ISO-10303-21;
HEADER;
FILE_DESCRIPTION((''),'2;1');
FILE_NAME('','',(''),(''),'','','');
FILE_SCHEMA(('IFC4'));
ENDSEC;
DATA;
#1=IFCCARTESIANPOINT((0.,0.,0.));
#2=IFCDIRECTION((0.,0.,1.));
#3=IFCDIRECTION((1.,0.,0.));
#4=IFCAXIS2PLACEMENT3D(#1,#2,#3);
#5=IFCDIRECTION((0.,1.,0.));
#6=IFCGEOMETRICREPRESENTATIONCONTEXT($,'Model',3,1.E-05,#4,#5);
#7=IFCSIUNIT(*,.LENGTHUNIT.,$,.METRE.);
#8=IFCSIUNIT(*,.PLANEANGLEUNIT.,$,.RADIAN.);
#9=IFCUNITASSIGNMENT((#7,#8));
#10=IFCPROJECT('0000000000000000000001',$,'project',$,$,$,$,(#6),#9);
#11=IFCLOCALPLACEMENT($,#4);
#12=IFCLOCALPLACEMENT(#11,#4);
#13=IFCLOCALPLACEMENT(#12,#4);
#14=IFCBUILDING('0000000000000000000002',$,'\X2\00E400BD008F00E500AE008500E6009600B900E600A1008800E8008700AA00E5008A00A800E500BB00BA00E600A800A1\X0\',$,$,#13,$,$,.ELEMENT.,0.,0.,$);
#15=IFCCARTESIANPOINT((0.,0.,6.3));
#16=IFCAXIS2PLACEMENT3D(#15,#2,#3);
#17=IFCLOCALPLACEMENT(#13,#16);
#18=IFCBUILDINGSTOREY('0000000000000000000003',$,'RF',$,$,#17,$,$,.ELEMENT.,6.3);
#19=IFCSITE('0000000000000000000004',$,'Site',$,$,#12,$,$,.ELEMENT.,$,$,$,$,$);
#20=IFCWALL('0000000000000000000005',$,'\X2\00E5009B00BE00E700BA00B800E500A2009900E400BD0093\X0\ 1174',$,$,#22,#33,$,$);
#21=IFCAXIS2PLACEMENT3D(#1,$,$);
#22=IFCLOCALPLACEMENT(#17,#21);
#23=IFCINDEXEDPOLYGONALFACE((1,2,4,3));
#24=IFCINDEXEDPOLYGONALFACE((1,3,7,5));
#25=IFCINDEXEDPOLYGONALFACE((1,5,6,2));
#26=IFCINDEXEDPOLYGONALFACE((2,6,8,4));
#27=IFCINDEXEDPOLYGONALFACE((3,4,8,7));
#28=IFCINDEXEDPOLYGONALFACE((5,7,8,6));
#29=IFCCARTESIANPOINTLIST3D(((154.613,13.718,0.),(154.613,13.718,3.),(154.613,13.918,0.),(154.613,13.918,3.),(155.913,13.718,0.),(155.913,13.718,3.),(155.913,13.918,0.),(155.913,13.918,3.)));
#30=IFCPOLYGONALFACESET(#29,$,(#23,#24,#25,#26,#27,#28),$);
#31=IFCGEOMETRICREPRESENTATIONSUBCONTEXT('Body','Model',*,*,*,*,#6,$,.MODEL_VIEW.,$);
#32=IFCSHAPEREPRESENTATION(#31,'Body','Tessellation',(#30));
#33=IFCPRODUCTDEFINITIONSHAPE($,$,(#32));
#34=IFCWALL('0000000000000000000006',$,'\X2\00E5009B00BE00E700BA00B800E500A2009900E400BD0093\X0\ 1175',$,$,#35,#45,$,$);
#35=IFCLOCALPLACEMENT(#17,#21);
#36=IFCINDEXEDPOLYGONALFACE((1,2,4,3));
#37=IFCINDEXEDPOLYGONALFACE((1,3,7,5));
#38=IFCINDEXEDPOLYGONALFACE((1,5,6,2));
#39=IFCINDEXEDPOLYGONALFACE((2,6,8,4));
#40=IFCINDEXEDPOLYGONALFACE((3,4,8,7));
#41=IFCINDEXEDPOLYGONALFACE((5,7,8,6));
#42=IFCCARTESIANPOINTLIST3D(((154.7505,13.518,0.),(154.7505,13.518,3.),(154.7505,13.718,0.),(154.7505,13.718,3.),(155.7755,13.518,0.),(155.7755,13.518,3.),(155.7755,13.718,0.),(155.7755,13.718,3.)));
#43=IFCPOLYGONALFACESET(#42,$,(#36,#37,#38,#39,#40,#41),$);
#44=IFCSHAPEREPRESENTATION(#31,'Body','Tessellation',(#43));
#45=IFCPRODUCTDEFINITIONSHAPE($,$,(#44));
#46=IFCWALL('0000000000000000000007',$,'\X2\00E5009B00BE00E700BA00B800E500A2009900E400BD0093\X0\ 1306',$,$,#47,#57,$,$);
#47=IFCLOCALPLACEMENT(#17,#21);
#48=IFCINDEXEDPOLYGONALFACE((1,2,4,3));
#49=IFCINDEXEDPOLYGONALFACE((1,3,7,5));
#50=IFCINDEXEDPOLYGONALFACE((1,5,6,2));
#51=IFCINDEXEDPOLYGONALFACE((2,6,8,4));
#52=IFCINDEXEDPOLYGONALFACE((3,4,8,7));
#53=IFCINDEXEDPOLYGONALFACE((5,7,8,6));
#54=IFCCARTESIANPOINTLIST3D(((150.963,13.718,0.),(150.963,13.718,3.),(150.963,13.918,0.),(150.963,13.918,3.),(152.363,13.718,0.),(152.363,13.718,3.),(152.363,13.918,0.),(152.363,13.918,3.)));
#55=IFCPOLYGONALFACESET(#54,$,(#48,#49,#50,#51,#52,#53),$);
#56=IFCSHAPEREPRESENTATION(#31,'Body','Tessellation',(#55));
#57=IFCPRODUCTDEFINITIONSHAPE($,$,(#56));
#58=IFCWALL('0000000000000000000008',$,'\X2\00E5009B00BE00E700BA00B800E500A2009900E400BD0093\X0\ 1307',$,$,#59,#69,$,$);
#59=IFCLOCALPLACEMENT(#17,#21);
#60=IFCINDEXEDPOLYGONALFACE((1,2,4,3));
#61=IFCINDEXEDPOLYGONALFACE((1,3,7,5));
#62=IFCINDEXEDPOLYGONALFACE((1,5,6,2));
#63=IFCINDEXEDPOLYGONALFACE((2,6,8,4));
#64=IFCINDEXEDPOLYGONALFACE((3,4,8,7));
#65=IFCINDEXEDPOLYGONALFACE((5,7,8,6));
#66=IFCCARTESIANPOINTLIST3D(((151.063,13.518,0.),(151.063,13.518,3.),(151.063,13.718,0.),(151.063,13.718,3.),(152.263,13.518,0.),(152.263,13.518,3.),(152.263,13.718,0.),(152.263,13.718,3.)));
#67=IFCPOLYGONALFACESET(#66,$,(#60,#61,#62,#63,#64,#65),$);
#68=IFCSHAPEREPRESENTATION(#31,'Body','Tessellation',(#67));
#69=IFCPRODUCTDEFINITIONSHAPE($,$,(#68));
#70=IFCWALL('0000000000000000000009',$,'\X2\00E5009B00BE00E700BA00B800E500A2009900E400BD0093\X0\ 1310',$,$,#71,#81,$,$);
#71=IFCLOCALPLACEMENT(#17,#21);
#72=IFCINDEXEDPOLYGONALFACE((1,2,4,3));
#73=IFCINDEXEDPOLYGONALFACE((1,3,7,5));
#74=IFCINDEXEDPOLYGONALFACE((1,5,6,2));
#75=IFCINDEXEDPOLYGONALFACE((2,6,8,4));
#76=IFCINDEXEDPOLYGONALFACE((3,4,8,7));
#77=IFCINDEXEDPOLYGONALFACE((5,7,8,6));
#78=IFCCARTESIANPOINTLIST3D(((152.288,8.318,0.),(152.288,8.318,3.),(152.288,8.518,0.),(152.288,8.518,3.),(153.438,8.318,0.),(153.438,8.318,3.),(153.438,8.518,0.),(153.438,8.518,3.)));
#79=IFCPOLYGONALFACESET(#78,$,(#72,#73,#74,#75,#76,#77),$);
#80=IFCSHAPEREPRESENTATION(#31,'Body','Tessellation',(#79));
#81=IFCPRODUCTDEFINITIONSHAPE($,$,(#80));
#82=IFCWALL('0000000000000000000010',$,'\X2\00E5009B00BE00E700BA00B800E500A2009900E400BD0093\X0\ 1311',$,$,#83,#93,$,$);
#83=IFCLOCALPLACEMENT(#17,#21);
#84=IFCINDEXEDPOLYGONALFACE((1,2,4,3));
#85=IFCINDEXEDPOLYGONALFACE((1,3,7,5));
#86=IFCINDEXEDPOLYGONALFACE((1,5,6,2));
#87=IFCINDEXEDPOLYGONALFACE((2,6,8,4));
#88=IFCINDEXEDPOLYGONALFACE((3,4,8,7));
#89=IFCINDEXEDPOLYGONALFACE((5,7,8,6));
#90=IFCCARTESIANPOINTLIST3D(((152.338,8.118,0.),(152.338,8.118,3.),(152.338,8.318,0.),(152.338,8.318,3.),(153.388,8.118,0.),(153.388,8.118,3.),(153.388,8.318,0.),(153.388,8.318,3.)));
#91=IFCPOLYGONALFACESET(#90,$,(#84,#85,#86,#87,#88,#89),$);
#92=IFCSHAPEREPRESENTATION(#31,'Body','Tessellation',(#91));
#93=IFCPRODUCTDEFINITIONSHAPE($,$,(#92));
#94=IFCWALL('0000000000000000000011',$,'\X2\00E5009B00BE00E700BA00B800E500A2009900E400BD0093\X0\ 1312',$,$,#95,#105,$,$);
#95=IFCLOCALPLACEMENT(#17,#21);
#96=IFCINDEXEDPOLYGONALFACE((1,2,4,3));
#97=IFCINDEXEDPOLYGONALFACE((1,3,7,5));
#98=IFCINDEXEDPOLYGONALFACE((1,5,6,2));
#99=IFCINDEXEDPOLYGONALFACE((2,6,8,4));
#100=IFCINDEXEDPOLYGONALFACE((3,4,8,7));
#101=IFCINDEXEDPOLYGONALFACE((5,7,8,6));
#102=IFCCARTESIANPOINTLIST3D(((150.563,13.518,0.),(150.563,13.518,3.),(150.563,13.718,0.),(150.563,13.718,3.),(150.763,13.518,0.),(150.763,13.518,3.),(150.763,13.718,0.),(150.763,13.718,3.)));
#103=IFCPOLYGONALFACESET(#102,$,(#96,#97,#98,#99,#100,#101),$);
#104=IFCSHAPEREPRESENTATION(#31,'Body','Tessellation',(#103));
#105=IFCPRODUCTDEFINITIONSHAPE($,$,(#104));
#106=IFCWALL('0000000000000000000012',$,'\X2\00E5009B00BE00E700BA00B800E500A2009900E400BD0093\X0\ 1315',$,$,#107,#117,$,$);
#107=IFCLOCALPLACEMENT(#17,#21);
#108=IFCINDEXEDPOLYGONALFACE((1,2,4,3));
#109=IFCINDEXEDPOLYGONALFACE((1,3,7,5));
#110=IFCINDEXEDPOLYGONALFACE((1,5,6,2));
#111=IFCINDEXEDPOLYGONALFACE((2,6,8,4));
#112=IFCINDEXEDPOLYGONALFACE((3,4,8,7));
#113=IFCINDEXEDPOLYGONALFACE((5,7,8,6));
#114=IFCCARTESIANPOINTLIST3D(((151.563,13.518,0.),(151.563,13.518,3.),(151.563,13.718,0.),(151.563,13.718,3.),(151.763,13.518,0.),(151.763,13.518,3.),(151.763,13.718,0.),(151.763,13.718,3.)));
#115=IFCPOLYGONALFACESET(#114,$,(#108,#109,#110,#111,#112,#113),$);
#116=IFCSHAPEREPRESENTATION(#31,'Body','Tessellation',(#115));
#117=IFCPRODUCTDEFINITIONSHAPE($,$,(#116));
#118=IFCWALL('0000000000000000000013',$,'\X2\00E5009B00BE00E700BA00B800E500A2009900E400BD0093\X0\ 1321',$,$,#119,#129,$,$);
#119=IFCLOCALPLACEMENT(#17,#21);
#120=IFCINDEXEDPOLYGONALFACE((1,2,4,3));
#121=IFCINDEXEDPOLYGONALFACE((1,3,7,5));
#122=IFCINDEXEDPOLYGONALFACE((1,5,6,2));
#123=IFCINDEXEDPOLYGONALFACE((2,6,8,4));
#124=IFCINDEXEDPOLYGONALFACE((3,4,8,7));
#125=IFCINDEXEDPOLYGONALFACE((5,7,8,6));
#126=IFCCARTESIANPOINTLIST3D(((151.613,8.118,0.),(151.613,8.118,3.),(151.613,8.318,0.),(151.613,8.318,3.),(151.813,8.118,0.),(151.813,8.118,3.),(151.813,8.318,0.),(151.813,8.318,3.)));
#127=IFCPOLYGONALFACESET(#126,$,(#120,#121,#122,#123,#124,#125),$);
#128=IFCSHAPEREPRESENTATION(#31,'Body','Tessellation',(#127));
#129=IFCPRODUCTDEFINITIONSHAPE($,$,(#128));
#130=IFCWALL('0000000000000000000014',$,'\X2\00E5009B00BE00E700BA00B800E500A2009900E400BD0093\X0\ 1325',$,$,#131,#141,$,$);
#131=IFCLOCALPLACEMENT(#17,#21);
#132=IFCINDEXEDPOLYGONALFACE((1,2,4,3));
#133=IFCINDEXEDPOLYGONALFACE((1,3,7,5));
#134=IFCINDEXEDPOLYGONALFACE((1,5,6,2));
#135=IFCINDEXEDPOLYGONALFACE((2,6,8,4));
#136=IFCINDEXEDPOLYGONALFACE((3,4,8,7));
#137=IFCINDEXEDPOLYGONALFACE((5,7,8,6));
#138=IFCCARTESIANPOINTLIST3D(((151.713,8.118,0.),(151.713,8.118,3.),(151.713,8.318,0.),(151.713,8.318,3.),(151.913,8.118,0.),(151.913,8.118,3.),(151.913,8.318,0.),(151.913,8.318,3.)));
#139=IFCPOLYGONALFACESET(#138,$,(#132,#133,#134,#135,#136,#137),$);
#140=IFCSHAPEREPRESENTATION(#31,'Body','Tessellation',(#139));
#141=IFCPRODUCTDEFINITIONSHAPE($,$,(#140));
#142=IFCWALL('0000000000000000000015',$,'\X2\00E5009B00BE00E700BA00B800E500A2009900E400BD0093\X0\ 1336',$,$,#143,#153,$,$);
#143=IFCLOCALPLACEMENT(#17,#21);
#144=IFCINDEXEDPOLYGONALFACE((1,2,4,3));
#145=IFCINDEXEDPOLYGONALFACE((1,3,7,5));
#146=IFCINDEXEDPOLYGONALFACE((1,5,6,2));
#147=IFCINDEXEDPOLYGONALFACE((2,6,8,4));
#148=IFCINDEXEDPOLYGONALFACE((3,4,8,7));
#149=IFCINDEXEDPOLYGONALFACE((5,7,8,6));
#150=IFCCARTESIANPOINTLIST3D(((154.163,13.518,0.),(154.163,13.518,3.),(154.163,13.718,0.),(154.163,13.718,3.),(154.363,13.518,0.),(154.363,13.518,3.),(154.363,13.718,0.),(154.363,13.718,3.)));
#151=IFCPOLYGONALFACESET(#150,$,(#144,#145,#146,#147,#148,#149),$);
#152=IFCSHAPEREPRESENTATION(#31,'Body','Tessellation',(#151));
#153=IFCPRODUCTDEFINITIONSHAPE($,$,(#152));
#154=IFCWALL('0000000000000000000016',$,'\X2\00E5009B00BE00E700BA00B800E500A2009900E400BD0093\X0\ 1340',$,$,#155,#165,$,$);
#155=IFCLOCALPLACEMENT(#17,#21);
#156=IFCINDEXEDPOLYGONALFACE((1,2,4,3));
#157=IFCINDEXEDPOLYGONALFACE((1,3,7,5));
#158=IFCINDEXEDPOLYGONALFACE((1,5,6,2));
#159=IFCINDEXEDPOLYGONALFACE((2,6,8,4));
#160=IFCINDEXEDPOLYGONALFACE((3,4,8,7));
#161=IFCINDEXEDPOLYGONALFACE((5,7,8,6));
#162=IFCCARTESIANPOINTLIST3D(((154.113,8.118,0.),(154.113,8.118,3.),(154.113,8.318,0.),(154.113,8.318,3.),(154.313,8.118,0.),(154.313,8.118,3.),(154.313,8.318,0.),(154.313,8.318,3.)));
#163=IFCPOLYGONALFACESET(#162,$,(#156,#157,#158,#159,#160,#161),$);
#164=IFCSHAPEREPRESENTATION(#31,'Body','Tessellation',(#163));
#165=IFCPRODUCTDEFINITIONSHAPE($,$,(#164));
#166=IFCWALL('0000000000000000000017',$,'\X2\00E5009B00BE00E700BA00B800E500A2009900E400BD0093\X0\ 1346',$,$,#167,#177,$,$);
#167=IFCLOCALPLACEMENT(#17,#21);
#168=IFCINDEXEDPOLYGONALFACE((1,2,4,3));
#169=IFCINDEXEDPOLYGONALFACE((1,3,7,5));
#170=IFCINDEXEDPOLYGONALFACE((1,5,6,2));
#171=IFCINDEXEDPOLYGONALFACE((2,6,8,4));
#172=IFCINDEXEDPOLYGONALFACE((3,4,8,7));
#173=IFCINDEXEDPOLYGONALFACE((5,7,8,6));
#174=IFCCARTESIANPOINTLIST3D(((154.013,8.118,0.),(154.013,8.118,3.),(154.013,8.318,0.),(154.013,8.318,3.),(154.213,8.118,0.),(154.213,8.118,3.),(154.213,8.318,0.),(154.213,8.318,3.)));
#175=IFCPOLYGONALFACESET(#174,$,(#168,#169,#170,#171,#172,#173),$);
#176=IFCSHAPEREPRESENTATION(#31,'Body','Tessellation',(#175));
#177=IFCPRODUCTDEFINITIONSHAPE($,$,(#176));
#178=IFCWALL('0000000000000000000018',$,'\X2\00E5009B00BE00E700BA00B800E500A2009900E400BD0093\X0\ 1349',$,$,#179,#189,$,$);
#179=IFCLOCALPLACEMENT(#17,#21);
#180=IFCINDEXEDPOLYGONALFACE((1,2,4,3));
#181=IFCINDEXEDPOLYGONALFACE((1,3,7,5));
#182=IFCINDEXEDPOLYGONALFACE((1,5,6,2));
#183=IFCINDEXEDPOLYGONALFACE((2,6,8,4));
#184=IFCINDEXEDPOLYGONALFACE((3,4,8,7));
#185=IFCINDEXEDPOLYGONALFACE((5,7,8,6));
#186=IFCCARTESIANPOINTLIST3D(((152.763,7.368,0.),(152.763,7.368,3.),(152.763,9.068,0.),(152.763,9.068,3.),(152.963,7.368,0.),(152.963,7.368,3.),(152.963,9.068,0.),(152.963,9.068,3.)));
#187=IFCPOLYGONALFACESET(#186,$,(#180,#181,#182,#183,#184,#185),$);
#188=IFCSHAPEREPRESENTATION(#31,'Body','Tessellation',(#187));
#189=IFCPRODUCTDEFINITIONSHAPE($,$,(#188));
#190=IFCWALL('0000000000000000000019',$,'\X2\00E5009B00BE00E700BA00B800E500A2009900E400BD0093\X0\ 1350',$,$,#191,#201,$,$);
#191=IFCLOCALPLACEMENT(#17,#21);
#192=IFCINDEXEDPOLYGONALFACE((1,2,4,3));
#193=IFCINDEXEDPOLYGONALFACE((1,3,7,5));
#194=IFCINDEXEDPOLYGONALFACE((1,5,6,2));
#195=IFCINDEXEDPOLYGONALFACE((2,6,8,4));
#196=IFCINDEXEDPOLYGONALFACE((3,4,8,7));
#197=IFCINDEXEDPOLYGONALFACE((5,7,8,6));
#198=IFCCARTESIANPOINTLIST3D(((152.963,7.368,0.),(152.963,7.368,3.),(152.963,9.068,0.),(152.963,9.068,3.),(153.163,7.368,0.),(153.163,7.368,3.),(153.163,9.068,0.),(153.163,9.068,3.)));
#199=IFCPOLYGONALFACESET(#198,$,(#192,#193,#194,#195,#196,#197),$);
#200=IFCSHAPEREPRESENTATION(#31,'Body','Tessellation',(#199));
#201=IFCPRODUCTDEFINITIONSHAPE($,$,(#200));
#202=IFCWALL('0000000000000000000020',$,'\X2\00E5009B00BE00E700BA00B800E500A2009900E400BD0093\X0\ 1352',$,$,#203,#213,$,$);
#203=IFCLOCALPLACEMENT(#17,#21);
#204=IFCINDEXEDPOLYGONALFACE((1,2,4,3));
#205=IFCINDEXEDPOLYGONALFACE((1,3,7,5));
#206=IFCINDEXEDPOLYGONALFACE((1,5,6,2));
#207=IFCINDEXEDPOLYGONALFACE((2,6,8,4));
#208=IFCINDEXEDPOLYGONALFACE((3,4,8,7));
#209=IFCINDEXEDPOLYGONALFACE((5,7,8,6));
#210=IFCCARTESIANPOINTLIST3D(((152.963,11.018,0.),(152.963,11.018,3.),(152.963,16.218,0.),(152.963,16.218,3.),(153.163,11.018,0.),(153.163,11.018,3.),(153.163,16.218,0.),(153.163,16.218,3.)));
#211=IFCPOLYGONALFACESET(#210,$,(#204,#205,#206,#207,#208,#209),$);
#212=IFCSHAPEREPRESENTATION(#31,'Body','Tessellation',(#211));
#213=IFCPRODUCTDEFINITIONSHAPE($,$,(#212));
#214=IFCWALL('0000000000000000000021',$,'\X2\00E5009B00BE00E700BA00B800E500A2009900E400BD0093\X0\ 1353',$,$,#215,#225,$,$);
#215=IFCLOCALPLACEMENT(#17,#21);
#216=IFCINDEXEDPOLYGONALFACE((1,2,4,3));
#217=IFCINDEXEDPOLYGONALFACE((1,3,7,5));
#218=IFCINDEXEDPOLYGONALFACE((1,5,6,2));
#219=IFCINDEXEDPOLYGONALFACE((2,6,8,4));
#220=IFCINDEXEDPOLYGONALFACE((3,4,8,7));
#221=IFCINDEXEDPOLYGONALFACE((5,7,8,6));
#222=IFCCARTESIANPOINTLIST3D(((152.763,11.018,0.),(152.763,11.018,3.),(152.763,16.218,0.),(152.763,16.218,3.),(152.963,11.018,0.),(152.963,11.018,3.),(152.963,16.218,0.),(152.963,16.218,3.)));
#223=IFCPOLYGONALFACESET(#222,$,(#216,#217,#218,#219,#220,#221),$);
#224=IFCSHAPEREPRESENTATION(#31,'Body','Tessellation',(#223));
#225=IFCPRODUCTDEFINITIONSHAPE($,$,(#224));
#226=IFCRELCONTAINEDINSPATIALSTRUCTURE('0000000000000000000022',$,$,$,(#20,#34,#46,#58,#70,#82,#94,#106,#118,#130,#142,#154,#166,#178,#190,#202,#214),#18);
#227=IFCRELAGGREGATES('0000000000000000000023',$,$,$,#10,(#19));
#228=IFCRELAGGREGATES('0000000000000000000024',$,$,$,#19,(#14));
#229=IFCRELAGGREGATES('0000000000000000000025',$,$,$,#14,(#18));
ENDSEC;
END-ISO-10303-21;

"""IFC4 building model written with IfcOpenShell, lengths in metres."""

from ifc_helpers import new_model, si_unit, direction, frame, frame_2d, origin_with_axes, place, context, subcontext, project, spatial, rectangle, extrude, element, save


model = new_model("IFC4")

# Units and contexts
model_context = context("Model", 3, precision=1e-05, world=origin_with_axes(), true_north=direction((0.0, 1.0, 0.0)))
body_context = subcontext(model_context, "Body", "Model", "MODEL_VIEW")
ifc_project = project(units=[si_unit("LENGTHUNIT", "METRE"), si_unit("PLANEANGLEUNIT", "RADIAN")], contexts=[model_context])

# Site, building, storey
placement = place(None, origin_with_axes())
site_placement = place(placement, origin_with_axes())
site = spatial("IfcSite", under=ifc_project, at=site_placement, Name="Site", CompositionType="ELEMENT")
building_placement = place(site_placement, origin_with_axes())
building = spatial("IfcBuilding", under=site, at=building_placement, Name="ä½\u008få®\u0085æ\u0096¹æ¡\u0088è\u0087ªå\u008a¨å»ºæ¨¡", CompositionType="ELEMENT", ElevationOfRefHeight=0.0, ElevationOfTerrain=0.0)
storey_placement = place(building_placement, frame((0.0, 0.0, 6.3), z_axis=(0.0, 0.0, 1.0), x_axis=(1.0, 0.0, 0.0)))
storey = spatial("IfcBuildingStorey", under=building, at=storey_placement, Name="RF", CompositionType="ELEMENT", Elevation=6.3)

# Walls
wall_1_placement = place(storey_placement, frame((155.263, 13.818, 0.0), z_axis=(0.0, 0.0, 1.0), x_axis=(1.0, 0.0, 0.0)))
element("IfcWall", 1, at=wall_1_placement, inside=storey, Name="å\u009b¾çº¸å¢\u0099ä½\u0093 1174", context=body_context, shape_type="SweptSolid", body=[
    extrude(rectangle(XDim=1.3, YDim=0.2, at=frame_2d((0.0, 0.0), x_axis=(1.0, 0.0, 0.0))), frame((0.0, 0.0, 0.0), z_axis=(0.0, 0.0, 1.0)), (0.0, 0.0, 1.0), 3.0),
])
wall_2_placement = place(storey_placement, frame((155.263, 13.618, 0.0), z_axis=(0.0, 0.0, 1.0), x_axis=(1.0, 0.0, 0.0)))
element("IfcWall", 2, at=wall_2_placement, inside=storey, Name="å\u009b¾çº¸å¢\u0099ä½\u0093 1175", context=body_context, shape_type="SweptSolid", body=[
    extrude(rectangle(XDim=1.025, YDim=0.2, at=frame_2d((0.0, 0.0), x_axis=(1.0, 0.0, 0.0))), frame((0.0, 0.0, 0.0), z_axis=(0.0, 0.0, 1.0)), (0.0, 0.0, 1.0), 3.0),
])
wall_3_placement = place(storey_placement, frame((151.663, 13.818, 0.0), z_axis=(0.0, 0.0, 1.0), x_axis=(1.0, 0.0, 0.0)))
element("IfcWall", 3, at=wall_3_placement, inside=storey, Name="å\u009b¾çº¸å¢\u0099ä½\u0093 1306", context=body_context, shape_type="SweptSolid", body=[
    extrude(rectangle(XDim=1.4, YDim=0.2, at=frame_2d((0.0, 0.0), x_axis=(1.0, 0.0, 0.0))), frame((0.0, 0.0, 0.0), z_axis=(0.0, 0.0, 1.0)), (0.0, 0.0, 1.0), 3.0),
])
wall_4_placement = place(storey_placement, frame((151.663, 13.618, 0.0), z_axis=(0.0, 0.0, 1.0), x_axis=(1.0, 0.0, 0.0)))
element("IfcWall", 4, at=wall_4_placement, inside=storey, Name="å\u009b¾çº¸å¢\u0099ä½\u0093 1307", context=body_context, shape_type="SweptSolid", body=[
    extrude(rectangle(XDim=1.2, YDim=0.2, at=frame_2d((0.0, 0.0), x_axis=(1.0, 0.0, 0.0))), frame((0.0, 0.0, 0.0), z_axis=(0.0, 0.0, 1.0)), (0.0, 0.0, 1.0), 3.0),
])
wall_5_placement = place(storey_placement, frame((152.863, 8.418, 0.0), z_axis=(0.0, 0.0, 1.0), x_axis=(-1.0, 0.0, 0.0)))
element("IfcWall", 5, at=wall_5_placement, inside=storey, Name="å\u009b¾çº¸å¢\u0099ä½\u0093 1310", context=body_context, shape_type="SweptSolid", body=[
    extrude(rectangle(XDim=1.15, YDim=0.2, at=frame_2d((0.0, 0.0), x_axis=(1.0, 0.0, 0.0))), frame((0.0, 0.0, 0.0), z_axis=(0.0, 0.0, 1.0)), (0.0, 0.0, 1.0), 3.0),
])
wall_6_placement = place(storey_placement, frame((152.863, 8.218, 0.0), z_axis=(0.0, 0.0, 1.0), x_axis=(-1.0, 0.0, 0.0)))
element("IfcWall", 6, at=wall_6_placement, inside=storey, Name="å\u009b¾çº¸å¢\u0099ä½\u0093 1311", context=body_context, shape_type="SweptSolid", body=[
    extrude(rectangle(XDim=1.05, YDim=0.2, at=frame_2d((0.0, 0.0), x_axis=(1.0, 0.0, 0.0))), frame((0.0, 0.0, 0.0), z_axis=(0.0, 0.0, 1.0)), (0.0, 0.0, 1.0), 3.0),
])
for number, where, z_axis, x_axis, name in (
    (7, (150.663, 13.618, 0.0), (0.0, 0.0, 1.0), (0.0, 1.0, 0.0), "å\u009b¾çº¸å¢\u0099ä½\u0093 1312"),
    (8, (151.663, 13.618, 0.0), (0.0, 0.0, 1.0), (0.0, 1.0, 0.0), "å\u009b¾çº¸å¢\u0099ä½\u0093 1315"),
    (9, (151.713, 8.218, 0.0), (0.0, 0.0, 1.0), (0.0, 1.0, 0.0), "å\u009b¾çº¸å¢\u0099ä½\u0093 1321"),
    (10, (151.813, 8.218, 0.0), (0.0, 0.0, 1.0), (0.0, -1.0, 0.0), "å\u009b¾çº¸å¢\u0099ä½\u0093 1325"),
    (11, (154.263, 13.618, 0.0), (0.0, 0.0, 1.0), (0.0, 1.0, 0.0), "å\u009b¾çº¸å¢\u0099ä½\u0093 1336"),
    (12, (154.213, 8.218, 0.0), (0.0, 0.0, 1.0), (0.0, 1.0, 0.0), "å\u009b¾çº¸å¢\u0099ä½\u0093 1340"),
    (13, (154.113, 8.218, 0.0), (0.0, 0.0, 1.0), (0.0, -1.0, 0.0), "å\u009b¾çº¸å¢\u0099ä½\u0093 1346"),
):
    element("IfcWall", number, at=place(storey_placement, frame(where, z_axis=z_axis, x_axis=x_axis)), inside=storey, Name=name, context=body_context, shape_type="SweptSolid", body=[
        extrude(rectangle(XDim=0.2, YDim=0.2, at=frame_2d((0.0, 0.0), x_axis=(1.0, 0.0, 0.0))), frame((0.0, 0.0, 0.0), z_axis=(0.0, 0.0, 1.0)), (0.0, 0.0, 1.0), 3.0),
    ])
for number, where, z_axis, x_axis, name in (
    (14, (152.863, 8.218, 0.0), (0.0, 0.0, 1.0), (0.0, -1.0, 0.0), "å\u009b¾çº¸å¢\u0099ä½\u0093 1349"),
    (15, (153.063, 8.218, 0.0), (0.0, 0.0, 1.0), (0.0, -1.0, 0.0), "å\u009b¾çº¸å¢\u0099ä½\u0093 1350"),
):
    element("IfcWall", number, at=place(storey_placement, frame(where, z_axis=z_axis, x_axis=x_axis)), inside=storey, Name=name, context=body_context, shape_type="SweptSolid", body=[
        extrude(rectangle(XDim=1.7, YDim=0.2, at=frame_2d((0.0, 0.0), x_axis=(1.0, 0.0, 0.0))), frame((0.0, 0.0, 0.0), z_axis=(0.0, 0.0, 1.0)), (0.0, 0.0, 1.0), 3.0),
    ])
for number, where, z_axis, x_axis, name in (
    (16, (153.063, 13.618, 0.0), (0.0, 0.0, 1.0), (0.0, -1.0, 0.0), "å\u009b¾çº¸å¢\u0099ä½\u0093 1352"),
    (17, (152.863, 13.618, 0.0), (0.0, 0.0, 1.0), (0.0, -1.0, 0.0), "å\u009b¾çº¸å¢\u0099ä½\u0093 1353"),
):
    element("IfcWall", number, at=place(storey_placement, frame(where, z_axis=z_axis, x_axis=x_axis)), inside=storey, Name=name, context=body_context, shape_type="SweptSolid", body=[
        extrude(rectangle(XDim=5.2, YDim=0.2, at=frame_2d((0.0, 0.0), x_axis=(1.0, 0.0, 0.0))), frame((0.0, 0.0, 0.0), z_axis=(0.0, 0.0, 1.0)), (0.0, 0.0, 1.0), 3.0),
    ])

save(model, "model.ifc")
